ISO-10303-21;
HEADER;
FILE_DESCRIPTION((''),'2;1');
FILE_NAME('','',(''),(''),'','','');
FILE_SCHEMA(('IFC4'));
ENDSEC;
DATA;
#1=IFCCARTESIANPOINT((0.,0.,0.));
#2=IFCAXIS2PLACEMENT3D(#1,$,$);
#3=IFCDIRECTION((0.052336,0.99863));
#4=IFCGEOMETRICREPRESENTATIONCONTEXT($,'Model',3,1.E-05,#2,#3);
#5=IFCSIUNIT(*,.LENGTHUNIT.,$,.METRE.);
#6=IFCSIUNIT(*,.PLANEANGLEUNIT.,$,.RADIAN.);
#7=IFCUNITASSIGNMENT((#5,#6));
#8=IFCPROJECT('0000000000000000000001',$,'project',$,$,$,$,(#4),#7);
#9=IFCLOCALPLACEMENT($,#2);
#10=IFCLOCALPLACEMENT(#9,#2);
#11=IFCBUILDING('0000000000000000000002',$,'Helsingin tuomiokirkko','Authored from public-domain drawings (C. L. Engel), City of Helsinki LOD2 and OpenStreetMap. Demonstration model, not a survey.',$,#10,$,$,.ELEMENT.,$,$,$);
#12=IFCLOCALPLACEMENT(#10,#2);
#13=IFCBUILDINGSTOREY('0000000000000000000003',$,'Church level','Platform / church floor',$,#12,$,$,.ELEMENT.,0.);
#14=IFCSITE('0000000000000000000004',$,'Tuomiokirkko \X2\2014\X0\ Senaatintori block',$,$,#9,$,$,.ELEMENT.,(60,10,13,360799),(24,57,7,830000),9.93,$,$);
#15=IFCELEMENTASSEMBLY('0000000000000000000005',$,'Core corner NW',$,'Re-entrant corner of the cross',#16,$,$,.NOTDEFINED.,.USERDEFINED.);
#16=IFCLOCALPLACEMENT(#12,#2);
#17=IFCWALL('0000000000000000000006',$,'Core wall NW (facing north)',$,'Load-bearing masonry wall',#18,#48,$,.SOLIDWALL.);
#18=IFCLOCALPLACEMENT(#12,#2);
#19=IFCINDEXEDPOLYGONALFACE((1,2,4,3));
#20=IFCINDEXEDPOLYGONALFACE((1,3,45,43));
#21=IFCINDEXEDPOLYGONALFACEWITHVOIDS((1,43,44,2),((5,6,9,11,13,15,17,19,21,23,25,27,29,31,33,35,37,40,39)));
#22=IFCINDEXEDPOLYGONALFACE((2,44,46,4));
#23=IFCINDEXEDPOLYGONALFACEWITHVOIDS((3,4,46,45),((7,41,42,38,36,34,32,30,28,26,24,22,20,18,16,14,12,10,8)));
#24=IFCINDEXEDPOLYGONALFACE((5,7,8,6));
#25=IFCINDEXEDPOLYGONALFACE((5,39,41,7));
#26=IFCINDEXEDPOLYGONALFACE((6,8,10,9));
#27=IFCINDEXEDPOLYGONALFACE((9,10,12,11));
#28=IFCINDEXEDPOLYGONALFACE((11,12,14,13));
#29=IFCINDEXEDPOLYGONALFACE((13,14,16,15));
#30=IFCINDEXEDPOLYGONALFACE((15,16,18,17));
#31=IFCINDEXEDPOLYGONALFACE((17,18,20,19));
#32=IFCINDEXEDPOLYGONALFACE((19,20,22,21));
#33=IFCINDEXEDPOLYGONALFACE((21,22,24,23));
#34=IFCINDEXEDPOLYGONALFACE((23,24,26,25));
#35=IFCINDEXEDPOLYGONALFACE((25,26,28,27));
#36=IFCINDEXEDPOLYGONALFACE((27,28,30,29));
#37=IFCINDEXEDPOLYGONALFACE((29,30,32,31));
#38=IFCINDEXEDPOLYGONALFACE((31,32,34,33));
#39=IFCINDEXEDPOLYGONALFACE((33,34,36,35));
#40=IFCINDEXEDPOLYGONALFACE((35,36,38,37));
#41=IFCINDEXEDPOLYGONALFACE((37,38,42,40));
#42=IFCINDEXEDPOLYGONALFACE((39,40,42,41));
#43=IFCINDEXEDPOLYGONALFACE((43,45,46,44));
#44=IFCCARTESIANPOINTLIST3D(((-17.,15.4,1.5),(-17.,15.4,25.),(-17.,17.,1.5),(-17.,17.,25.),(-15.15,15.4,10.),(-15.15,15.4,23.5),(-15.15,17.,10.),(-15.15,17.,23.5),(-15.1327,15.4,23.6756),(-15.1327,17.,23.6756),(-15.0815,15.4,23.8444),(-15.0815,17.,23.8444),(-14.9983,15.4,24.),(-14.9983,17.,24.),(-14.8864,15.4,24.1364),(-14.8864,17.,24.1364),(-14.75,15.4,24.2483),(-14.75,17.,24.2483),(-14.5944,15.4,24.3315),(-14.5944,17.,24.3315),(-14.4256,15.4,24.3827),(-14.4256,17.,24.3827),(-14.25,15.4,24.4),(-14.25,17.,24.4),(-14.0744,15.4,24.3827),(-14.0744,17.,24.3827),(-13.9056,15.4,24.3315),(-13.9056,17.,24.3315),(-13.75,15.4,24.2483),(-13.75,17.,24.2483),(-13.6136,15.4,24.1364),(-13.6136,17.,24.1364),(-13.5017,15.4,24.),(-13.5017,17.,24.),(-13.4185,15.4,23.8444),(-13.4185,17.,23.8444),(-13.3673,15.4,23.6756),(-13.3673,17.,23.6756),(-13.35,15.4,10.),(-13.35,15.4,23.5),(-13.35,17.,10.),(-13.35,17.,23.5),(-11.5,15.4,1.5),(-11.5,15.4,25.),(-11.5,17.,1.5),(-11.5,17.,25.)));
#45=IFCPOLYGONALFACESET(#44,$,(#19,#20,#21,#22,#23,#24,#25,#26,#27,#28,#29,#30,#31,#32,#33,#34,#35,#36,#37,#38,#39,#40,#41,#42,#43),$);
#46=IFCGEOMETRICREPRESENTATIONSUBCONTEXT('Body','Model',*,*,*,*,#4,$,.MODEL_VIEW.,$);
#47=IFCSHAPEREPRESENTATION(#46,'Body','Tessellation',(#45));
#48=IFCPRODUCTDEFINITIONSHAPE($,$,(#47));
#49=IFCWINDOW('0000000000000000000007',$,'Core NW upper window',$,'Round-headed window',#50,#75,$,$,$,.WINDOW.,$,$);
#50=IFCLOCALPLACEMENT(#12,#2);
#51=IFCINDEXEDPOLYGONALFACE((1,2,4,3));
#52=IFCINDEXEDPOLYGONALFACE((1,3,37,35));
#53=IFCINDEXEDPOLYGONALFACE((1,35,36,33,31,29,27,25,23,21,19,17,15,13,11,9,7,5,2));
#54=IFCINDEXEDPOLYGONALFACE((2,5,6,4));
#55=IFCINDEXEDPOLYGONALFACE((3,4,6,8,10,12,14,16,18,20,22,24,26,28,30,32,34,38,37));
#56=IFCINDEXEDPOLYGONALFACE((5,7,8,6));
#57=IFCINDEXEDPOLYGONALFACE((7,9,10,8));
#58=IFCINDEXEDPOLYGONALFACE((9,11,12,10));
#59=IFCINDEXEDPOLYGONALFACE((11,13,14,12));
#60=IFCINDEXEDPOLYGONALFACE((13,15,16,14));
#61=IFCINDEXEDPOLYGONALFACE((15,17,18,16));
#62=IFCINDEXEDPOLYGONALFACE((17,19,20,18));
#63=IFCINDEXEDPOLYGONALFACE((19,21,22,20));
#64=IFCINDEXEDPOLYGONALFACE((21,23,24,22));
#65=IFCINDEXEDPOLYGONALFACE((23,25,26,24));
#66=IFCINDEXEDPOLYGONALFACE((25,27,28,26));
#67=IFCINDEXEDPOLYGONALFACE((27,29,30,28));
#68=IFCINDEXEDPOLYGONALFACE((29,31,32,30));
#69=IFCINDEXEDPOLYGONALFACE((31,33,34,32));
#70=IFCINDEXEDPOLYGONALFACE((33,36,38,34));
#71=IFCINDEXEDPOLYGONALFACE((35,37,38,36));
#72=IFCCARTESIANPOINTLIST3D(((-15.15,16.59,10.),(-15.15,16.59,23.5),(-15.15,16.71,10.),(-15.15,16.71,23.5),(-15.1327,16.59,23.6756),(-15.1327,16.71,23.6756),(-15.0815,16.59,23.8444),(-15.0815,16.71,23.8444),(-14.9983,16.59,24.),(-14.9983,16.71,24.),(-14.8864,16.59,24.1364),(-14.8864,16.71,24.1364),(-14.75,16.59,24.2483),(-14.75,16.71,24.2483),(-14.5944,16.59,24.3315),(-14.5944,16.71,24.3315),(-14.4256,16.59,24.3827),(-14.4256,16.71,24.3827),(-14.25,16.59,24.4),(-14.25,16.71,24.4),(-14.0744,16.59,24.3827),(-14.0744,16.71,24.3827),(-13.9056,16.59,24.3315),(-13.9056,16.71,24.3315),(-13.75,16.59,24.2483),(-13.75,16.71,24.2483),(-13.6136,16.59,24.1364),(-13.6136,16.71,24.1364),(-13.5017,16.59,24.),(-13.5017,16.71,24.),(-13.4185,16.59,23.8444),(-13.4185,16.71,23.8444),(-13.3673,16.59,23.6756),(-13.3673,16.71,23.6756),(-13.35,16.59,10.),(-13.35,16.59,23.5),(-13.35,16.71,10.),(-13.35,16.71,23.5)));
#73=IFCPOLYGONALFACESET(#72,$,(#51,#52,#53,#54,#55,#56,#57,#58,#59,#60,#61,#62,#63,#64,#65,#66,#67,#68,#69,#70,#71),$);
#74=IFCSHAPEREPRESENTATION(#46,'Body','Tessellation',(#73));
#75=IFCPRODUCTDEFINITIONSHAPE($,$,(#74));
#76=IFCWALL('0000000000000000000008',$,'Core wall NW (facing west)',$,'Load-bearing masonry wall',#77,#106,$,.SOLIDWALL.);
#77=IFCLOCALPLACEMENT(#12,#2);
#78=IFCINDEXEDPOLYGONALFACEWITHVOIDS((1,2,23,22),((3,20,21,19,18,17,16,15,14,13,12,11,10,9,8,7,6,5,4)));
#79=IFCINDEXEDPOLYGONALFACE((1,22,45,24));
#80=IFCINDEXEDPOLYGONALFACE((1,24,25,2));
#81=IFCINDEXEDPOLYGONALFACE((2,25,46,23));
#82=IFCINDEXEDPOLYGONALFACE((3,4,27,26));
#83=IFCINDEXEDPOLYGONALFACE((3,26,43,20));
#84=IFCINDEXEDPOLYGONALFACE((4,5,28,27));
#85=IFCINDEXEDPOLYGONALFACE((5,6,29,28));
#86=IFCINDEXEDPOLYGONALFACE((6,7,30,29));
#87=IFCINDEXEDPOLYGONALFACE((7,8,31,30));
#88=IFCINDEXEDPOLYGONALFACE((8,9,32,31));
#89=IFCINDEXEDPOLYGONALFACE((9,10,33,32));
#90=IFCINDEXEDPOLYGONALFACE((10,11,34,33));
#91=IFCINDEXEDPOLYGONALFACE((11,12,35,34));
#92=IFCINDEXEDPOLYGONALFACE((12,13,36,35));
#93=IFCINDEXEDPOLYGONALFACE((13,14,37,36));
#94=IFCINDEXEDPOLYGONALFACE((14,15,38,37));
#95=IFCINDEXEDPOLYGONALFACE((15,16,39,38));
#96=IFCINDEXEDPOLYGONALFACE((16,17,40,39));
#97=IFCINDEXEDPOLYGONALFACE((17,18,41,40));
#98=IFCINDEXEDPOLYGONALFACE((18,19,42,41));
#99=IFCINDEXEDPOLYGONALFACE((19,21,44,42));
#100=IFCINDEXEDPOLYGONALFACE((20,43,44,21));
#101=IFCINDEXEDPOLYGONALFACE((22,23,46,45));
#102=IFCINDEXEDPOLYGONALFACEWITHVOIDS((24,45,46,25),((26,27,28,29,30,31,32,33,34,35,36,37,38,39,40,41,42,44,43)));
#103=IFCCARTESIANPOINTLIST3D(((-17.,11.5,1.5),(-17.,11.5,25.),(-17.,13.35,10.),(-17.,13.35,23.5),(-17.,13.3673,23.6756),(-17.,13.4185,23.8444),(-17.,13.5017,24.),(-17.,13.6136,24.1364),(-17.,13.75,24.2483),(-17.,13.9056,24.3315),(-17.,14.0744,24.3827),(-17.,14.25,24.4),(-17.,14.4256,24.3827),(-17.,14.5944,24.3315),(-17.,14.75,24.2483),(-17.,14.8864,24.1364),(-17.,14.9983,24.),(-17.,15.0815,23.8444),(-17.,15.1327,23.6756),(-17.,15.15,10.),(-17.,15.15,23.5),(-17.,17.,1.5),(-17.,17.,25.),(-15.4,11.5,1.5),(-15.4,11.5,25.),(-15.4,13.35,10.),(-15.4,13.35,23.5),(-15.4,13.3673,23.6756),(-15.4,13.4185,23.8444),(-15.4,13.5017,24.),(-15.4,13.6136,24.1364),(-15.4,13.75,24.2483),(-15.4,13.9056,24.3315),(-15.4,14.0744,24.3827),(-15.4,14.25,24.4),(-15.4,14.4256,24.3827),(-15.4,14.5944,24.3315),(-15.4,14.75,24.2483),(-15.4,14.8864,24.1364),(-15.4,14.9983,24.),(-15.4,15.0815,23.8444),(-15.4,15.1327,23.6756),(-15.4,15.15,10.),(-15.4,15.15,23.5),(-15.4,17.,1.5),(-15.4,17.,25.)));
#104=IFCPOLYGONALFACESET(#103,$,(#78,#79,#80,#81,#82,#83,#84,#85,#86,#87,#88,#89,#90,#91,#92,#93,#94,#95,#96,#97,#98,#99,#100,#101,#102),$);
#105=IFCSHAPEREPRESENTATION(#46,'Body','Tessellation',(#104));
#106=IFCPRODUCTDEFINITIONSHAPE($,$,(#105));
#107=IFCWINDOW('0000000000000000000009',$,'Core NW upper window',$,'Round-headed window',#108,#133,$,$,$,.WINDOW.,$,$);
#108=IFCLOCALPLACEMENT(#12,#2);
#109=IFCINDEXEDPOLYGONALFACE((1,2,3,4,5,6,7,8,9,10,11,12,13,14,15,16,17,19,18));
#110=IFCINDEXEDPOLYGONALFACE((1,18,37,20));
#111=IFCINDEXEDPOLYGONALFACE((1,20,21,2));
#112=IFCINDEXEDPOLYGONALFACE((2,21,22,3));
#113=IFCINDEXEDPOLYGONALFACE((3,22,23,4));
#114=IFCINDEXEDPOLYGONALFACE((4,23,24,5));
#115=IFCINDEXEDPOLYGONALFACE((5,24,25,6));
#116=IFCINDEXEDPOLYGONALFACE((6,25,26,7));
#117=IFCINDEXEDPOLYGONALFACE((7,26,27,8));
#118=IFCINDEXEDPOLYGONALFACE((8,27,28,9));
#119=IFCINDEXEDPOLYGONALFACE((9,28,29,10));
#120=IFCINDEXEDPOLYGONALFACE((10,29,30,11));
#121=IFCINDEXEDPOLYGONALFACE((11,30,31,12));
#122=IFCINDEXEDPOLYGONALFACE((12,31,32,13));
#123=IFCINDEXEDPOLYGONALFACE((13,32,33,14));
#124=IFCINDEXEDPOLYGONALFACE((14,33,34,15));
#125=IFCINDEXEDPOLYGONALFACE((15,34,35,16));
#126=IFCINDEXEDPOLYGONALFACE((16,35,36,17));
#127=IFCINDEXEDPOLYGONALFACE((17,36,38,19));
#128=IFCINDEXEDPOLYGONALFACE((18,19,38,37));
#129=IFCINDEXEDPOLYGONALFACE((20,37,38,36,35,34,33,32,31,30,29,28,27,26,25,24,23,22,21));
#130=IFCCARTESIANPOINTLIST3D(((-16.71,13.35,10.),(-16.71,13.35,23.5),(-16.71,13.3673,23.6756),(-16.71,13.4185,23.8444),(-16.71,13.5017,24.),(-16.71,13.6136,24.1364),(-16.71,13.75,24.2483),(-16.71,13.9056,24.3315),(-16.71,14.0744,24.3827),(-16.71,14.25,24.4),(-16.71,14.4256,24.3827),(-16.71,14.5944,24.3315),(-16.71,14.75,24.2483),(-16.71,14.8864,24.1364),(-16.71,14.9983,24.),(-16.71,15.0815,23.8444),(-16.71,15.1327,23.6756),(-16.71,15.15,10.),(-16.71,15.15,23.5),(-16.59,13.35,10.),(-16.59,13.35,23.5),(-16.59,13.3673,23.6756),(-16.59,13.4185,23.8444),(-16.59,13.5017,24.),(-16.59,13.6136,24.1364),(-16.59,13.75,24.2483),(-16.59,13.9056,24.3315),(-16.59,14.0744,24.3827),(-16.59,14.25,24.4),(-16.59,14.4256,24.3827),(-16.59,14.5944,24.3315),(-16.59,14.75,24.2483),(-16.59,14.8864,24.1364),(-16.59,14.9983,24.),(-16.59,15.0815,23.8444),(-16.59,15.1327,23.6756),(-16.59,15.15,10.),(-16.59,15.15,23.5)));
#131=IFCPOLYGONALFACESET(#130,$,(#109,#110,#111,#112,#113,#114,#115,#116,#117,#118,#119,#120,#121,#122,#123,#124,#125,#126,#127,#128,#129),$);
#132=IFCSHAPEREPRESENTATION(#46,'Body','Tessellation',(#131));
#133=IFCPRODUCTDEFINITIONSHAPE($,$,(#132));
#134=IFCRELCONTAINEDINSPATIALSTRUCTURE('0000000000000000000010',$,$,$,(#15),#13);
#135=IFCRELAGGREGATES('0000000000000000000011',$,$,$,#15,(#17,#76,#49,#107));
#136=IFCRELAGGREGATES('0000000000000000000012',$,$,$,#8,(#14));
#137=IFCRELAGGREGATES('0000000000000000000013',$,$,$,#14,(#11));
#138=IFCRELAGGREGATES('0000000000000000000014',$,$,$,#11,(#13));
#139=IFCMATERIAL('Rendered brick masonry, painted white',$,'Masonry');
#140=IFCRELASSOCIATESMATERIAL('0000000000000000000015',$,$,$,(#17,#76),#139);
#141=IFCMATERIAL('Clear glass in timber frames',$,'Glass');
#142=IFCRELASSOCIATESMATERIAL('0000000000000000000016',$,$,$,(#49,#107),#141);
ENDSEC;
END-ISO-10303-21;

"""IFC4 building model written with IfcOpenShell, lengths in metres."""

from ifc_helpers import new_model, si_unit, direction, frame, frame_2d, origin, place, context, subcontext, project, spatial, polyline, rectangle, outline, extrude, material, element, fill, aggregate, save


model = new_model("IFC4")

# Units and contexts
model_context = context("Model", 3, precision=1e-05, world=origin(), true_north=direction((0.052336, 0.99863)))
body_context = subcontext(model_context, "Body", "Model", "MODEL_VIEW")
ifc_project = project(units=[si_unit("LENGTHUNIT", "METRE"), si_unit("PLANEANGLEUNIT", "RADIAN")], contexts=[model_context])

# Site, building, storey
site_placement = place(None, origin())
site = spatial("IfcSite", under=ifc_project, at=site_placement, Name="Tuomiokirkko — Senaatintori block", CompositionType="ELEMENT", RefLatitude=(60, 10, 13, 360799), RefLongitude=(24, 57, 7, 830000), RefElevation=9.93)
building_placement = place(site_placement, origin())
building = spatial("IfcBuilding", under=site, at=building_placement, Name="Helsingin tuomiokirkko", Description="Authored from public-domain drawings (C. L. Engel), City of Helsinki LOD2 and OpenStreetMap. Demonstration model, not a survey.", CompositionType="ELEMENT")
storey_placement = place(building_placement, origin())
storey = spatial("IfcBuildingStorey", under=building, at=storey_placement, Name="Church level", Description="Platform / church floor", CompositionType="ELEMENT", Elevation=0.0)

# Element assembly, walls, openings, windows
ifc_material_1 = material(Name="Rendered brick masonry, painted white", Category="Masonry")
ifc_material_2 = material(Name="Clear glass in timber frames", Category="Glass")
assembly_1_placement = place(building_placement, origin())
assembly_1 = element("IfcElementAssembly", 1, at=assembly_1_placement, inside=storey, Name="Core corner NW", ObjectType="Re-entrant corner of the cross", AssemblyPlace="NOTDEFINED", PredefinedType="USERDEFINED")
wall_1_placement = place(building_placement, origin())
wall_1 = element("IfcWall", 2, at=wall_1_placement, material=ifc_material_1, Name="Core wall NW (facing north)", ObjectType="Load-bearing masonry wall", PredefinedType="SOLIDWALL", context=body_context, shape_type="SweptSolid", body=[
    extrude(rectangle(XDim=5.5, YDim=1.6, at=frame_2d((0.0, 0.0), x_axis=(-1.0, 0.0))), frame((-14.25, 16.2, 1.5)), (0.0, 0.0, 1.0), 23.5),
])
opening_1_placement = place(building_placement, origin())
opening_1 = element("IfcOpeningElement", 3, at=opening_1_placement, cuts=wall_1, PredefinedType="OPENING", context=body_context, shape_type="SweptSolid", body=[
    extrude(outline(polyline([(-0.9, 0.0), (0.9, 0.0), (0.9, 13.5), (0.8827, 13.6756), (0.8315, 13.8444), (0.7483, 14.0), (0.6364, 14.1364), (0.5, 14.2483), (0.3444, 14.3315), (0.1756, 14.3827), (0.0, 14.4), (-0.1756, 14.3827), (-0.3444, 14.3315), (-0.5, 14.2483), (-0.6364, 14.1364), (-0.7483, 14.0), (-0.8315, 13.8444), (-0.8827, 13.6756), (-0.9, 13.5), (-0.9, 0.0)])), frame((-14.25, 15.2, 10.0), z_axis=(0.0, 1.0, 0.0), x_axis=(-1.0, 0.0, 0.0)), (0.0, 0.0, 1.0), 2.0),
])
window_1_placement = place(building_placement, origin())
window_1 = element("IfcWindow", 4, at=window_1_placement, material=ifc_material_2, Name="Core NW upper window", ObjectType="Round-headed window", PredefinedType="WINDOW", context=body_context, shape_type="SweptSolid", body=[
    extrude(outline(polyline([(-0.9, 0.0), (0.9, 0.0), (0.9, 13.5), (0.8827, 13.6756), (0.8315, 13.8444), (0.7483, 14.0), (0.6364, 14.1364), (0.5, 14.2483), (0.3444, 14.3315), (0.1756, 14.3827), (0.0, 14.4), (-0.1756, 14.3827), (-0.3444, 14.3315), (-0.5, 14.2483), (-0.6364, 14.1364), (-0.7483, 14.0), (-0.8315, 13.8444), (-0.8827, 13.6756), (-0.9, 13.5), (-0.9, 0.0)])), frame((-14.25, 16.59, 10.0), z_axis=(0.0, 1.0, 0.0), x_axis=(-1.0, 0.0, 0.0)), (0.0, 0.0, 1.0), 0.12),
])
fill(opening_1, window_1)
wall_2_placement = place(building_placement, origin())
wall_2 = element("IfcWall", 5, at=wall_2_placement, material=ifc_material_1, Name="Core wall NW (facing west)", ObjectType="Load-bearing masonry wall", PredefinedType="SOLIDWALL", context=body_context, shape_type="SweptSolid", body=[
    extrude(rectangle(XDim=5.5, YDim=1.6, at=frame_2d((0.0, 0.0), x_axis=(0.0, 1.0))), frame((-16.2, 14.25, 1.5)), (0.0, 0.0, 1.0), 23.5),
])
opening_2_placement = place(building_placement, origin())
opening_2 = element("IfcOpeningElement", 6, at=opening_2_placement, cuts=wall_2, PredefinedType="OPENING", context=body_context, shape_type="SweptSolid", body=[
    extrude(outline(polyline([(-0.9, 0.0), (0.9, 0.0), (0.9, 13.5), (0.8827, 13.6756), (0.8315, 13.8444), (0.7483, 14.0), (0.6364, 14.1364), (0.5, 14.2483), (0.3444, 14.3315), (0.1756, 14.3827), (0.0, 14.4), (-0.1756, 14.3827), (-0.3444, 14.3315), (-0.5, 14.2483), (-0.6364, 14.1364), (-0.7483, 14.0), (-0.8315, 13.8444), (-0.8827, 13.6756), (-0.9, 13.5), (-0.9, 0.0)])), frame((-17.2, 14.25, 10.0), z_axis=(1.0, 0.0, 0.0), x_axis=(0.0, 1.0, 0.0)), (0.0, 0.0, 1.0), 2.0),
])
window_2_placement = place(building_placement, origin())
window_2 = element("IfcWindow", 7, at=window_2_placement, material=ifc_material_2, Name="Core NW upper window", ObjectType="Round-headed window", PredefinedType="WINDOW", context=body_context, shape_type="SweptSolid", body=[
    extrude(outline(polyline([(-0.9, 0.0), (0.9, 0.0), (0.9, 13.5), (0.8827, 13.6756), (0.8315, 13.8444), (0.7483, 14.0), (0.6364, 14.1364), (0.5, 14.2483), (0.3444, 14.3315), (0.1756, 14.3827), (0.0, 14.4), (-0.1756, 14.3827), (-0.3444, 14.3315), (-0.5, 14.2483), (-0.6364, 14.1364), (-0.7483, 14.0), (-0.8315, 13.8444), (-0.8827, 13.6756), (-0.9, 13.5), (-0.9, 0.0)])), frame((-16.71, 14.25, 10.0), z_axis=(1.0, 0.0, 0.0), x_axis=(0.0, 1.0, 0.0)), (0.0, 0.0, 1.0), 0.12),
])
fill(opening_2, window_2)
aggregate(assembly_1, [wall_1, wall_2, window_1, window_2])

save(model, "model.ifc")
